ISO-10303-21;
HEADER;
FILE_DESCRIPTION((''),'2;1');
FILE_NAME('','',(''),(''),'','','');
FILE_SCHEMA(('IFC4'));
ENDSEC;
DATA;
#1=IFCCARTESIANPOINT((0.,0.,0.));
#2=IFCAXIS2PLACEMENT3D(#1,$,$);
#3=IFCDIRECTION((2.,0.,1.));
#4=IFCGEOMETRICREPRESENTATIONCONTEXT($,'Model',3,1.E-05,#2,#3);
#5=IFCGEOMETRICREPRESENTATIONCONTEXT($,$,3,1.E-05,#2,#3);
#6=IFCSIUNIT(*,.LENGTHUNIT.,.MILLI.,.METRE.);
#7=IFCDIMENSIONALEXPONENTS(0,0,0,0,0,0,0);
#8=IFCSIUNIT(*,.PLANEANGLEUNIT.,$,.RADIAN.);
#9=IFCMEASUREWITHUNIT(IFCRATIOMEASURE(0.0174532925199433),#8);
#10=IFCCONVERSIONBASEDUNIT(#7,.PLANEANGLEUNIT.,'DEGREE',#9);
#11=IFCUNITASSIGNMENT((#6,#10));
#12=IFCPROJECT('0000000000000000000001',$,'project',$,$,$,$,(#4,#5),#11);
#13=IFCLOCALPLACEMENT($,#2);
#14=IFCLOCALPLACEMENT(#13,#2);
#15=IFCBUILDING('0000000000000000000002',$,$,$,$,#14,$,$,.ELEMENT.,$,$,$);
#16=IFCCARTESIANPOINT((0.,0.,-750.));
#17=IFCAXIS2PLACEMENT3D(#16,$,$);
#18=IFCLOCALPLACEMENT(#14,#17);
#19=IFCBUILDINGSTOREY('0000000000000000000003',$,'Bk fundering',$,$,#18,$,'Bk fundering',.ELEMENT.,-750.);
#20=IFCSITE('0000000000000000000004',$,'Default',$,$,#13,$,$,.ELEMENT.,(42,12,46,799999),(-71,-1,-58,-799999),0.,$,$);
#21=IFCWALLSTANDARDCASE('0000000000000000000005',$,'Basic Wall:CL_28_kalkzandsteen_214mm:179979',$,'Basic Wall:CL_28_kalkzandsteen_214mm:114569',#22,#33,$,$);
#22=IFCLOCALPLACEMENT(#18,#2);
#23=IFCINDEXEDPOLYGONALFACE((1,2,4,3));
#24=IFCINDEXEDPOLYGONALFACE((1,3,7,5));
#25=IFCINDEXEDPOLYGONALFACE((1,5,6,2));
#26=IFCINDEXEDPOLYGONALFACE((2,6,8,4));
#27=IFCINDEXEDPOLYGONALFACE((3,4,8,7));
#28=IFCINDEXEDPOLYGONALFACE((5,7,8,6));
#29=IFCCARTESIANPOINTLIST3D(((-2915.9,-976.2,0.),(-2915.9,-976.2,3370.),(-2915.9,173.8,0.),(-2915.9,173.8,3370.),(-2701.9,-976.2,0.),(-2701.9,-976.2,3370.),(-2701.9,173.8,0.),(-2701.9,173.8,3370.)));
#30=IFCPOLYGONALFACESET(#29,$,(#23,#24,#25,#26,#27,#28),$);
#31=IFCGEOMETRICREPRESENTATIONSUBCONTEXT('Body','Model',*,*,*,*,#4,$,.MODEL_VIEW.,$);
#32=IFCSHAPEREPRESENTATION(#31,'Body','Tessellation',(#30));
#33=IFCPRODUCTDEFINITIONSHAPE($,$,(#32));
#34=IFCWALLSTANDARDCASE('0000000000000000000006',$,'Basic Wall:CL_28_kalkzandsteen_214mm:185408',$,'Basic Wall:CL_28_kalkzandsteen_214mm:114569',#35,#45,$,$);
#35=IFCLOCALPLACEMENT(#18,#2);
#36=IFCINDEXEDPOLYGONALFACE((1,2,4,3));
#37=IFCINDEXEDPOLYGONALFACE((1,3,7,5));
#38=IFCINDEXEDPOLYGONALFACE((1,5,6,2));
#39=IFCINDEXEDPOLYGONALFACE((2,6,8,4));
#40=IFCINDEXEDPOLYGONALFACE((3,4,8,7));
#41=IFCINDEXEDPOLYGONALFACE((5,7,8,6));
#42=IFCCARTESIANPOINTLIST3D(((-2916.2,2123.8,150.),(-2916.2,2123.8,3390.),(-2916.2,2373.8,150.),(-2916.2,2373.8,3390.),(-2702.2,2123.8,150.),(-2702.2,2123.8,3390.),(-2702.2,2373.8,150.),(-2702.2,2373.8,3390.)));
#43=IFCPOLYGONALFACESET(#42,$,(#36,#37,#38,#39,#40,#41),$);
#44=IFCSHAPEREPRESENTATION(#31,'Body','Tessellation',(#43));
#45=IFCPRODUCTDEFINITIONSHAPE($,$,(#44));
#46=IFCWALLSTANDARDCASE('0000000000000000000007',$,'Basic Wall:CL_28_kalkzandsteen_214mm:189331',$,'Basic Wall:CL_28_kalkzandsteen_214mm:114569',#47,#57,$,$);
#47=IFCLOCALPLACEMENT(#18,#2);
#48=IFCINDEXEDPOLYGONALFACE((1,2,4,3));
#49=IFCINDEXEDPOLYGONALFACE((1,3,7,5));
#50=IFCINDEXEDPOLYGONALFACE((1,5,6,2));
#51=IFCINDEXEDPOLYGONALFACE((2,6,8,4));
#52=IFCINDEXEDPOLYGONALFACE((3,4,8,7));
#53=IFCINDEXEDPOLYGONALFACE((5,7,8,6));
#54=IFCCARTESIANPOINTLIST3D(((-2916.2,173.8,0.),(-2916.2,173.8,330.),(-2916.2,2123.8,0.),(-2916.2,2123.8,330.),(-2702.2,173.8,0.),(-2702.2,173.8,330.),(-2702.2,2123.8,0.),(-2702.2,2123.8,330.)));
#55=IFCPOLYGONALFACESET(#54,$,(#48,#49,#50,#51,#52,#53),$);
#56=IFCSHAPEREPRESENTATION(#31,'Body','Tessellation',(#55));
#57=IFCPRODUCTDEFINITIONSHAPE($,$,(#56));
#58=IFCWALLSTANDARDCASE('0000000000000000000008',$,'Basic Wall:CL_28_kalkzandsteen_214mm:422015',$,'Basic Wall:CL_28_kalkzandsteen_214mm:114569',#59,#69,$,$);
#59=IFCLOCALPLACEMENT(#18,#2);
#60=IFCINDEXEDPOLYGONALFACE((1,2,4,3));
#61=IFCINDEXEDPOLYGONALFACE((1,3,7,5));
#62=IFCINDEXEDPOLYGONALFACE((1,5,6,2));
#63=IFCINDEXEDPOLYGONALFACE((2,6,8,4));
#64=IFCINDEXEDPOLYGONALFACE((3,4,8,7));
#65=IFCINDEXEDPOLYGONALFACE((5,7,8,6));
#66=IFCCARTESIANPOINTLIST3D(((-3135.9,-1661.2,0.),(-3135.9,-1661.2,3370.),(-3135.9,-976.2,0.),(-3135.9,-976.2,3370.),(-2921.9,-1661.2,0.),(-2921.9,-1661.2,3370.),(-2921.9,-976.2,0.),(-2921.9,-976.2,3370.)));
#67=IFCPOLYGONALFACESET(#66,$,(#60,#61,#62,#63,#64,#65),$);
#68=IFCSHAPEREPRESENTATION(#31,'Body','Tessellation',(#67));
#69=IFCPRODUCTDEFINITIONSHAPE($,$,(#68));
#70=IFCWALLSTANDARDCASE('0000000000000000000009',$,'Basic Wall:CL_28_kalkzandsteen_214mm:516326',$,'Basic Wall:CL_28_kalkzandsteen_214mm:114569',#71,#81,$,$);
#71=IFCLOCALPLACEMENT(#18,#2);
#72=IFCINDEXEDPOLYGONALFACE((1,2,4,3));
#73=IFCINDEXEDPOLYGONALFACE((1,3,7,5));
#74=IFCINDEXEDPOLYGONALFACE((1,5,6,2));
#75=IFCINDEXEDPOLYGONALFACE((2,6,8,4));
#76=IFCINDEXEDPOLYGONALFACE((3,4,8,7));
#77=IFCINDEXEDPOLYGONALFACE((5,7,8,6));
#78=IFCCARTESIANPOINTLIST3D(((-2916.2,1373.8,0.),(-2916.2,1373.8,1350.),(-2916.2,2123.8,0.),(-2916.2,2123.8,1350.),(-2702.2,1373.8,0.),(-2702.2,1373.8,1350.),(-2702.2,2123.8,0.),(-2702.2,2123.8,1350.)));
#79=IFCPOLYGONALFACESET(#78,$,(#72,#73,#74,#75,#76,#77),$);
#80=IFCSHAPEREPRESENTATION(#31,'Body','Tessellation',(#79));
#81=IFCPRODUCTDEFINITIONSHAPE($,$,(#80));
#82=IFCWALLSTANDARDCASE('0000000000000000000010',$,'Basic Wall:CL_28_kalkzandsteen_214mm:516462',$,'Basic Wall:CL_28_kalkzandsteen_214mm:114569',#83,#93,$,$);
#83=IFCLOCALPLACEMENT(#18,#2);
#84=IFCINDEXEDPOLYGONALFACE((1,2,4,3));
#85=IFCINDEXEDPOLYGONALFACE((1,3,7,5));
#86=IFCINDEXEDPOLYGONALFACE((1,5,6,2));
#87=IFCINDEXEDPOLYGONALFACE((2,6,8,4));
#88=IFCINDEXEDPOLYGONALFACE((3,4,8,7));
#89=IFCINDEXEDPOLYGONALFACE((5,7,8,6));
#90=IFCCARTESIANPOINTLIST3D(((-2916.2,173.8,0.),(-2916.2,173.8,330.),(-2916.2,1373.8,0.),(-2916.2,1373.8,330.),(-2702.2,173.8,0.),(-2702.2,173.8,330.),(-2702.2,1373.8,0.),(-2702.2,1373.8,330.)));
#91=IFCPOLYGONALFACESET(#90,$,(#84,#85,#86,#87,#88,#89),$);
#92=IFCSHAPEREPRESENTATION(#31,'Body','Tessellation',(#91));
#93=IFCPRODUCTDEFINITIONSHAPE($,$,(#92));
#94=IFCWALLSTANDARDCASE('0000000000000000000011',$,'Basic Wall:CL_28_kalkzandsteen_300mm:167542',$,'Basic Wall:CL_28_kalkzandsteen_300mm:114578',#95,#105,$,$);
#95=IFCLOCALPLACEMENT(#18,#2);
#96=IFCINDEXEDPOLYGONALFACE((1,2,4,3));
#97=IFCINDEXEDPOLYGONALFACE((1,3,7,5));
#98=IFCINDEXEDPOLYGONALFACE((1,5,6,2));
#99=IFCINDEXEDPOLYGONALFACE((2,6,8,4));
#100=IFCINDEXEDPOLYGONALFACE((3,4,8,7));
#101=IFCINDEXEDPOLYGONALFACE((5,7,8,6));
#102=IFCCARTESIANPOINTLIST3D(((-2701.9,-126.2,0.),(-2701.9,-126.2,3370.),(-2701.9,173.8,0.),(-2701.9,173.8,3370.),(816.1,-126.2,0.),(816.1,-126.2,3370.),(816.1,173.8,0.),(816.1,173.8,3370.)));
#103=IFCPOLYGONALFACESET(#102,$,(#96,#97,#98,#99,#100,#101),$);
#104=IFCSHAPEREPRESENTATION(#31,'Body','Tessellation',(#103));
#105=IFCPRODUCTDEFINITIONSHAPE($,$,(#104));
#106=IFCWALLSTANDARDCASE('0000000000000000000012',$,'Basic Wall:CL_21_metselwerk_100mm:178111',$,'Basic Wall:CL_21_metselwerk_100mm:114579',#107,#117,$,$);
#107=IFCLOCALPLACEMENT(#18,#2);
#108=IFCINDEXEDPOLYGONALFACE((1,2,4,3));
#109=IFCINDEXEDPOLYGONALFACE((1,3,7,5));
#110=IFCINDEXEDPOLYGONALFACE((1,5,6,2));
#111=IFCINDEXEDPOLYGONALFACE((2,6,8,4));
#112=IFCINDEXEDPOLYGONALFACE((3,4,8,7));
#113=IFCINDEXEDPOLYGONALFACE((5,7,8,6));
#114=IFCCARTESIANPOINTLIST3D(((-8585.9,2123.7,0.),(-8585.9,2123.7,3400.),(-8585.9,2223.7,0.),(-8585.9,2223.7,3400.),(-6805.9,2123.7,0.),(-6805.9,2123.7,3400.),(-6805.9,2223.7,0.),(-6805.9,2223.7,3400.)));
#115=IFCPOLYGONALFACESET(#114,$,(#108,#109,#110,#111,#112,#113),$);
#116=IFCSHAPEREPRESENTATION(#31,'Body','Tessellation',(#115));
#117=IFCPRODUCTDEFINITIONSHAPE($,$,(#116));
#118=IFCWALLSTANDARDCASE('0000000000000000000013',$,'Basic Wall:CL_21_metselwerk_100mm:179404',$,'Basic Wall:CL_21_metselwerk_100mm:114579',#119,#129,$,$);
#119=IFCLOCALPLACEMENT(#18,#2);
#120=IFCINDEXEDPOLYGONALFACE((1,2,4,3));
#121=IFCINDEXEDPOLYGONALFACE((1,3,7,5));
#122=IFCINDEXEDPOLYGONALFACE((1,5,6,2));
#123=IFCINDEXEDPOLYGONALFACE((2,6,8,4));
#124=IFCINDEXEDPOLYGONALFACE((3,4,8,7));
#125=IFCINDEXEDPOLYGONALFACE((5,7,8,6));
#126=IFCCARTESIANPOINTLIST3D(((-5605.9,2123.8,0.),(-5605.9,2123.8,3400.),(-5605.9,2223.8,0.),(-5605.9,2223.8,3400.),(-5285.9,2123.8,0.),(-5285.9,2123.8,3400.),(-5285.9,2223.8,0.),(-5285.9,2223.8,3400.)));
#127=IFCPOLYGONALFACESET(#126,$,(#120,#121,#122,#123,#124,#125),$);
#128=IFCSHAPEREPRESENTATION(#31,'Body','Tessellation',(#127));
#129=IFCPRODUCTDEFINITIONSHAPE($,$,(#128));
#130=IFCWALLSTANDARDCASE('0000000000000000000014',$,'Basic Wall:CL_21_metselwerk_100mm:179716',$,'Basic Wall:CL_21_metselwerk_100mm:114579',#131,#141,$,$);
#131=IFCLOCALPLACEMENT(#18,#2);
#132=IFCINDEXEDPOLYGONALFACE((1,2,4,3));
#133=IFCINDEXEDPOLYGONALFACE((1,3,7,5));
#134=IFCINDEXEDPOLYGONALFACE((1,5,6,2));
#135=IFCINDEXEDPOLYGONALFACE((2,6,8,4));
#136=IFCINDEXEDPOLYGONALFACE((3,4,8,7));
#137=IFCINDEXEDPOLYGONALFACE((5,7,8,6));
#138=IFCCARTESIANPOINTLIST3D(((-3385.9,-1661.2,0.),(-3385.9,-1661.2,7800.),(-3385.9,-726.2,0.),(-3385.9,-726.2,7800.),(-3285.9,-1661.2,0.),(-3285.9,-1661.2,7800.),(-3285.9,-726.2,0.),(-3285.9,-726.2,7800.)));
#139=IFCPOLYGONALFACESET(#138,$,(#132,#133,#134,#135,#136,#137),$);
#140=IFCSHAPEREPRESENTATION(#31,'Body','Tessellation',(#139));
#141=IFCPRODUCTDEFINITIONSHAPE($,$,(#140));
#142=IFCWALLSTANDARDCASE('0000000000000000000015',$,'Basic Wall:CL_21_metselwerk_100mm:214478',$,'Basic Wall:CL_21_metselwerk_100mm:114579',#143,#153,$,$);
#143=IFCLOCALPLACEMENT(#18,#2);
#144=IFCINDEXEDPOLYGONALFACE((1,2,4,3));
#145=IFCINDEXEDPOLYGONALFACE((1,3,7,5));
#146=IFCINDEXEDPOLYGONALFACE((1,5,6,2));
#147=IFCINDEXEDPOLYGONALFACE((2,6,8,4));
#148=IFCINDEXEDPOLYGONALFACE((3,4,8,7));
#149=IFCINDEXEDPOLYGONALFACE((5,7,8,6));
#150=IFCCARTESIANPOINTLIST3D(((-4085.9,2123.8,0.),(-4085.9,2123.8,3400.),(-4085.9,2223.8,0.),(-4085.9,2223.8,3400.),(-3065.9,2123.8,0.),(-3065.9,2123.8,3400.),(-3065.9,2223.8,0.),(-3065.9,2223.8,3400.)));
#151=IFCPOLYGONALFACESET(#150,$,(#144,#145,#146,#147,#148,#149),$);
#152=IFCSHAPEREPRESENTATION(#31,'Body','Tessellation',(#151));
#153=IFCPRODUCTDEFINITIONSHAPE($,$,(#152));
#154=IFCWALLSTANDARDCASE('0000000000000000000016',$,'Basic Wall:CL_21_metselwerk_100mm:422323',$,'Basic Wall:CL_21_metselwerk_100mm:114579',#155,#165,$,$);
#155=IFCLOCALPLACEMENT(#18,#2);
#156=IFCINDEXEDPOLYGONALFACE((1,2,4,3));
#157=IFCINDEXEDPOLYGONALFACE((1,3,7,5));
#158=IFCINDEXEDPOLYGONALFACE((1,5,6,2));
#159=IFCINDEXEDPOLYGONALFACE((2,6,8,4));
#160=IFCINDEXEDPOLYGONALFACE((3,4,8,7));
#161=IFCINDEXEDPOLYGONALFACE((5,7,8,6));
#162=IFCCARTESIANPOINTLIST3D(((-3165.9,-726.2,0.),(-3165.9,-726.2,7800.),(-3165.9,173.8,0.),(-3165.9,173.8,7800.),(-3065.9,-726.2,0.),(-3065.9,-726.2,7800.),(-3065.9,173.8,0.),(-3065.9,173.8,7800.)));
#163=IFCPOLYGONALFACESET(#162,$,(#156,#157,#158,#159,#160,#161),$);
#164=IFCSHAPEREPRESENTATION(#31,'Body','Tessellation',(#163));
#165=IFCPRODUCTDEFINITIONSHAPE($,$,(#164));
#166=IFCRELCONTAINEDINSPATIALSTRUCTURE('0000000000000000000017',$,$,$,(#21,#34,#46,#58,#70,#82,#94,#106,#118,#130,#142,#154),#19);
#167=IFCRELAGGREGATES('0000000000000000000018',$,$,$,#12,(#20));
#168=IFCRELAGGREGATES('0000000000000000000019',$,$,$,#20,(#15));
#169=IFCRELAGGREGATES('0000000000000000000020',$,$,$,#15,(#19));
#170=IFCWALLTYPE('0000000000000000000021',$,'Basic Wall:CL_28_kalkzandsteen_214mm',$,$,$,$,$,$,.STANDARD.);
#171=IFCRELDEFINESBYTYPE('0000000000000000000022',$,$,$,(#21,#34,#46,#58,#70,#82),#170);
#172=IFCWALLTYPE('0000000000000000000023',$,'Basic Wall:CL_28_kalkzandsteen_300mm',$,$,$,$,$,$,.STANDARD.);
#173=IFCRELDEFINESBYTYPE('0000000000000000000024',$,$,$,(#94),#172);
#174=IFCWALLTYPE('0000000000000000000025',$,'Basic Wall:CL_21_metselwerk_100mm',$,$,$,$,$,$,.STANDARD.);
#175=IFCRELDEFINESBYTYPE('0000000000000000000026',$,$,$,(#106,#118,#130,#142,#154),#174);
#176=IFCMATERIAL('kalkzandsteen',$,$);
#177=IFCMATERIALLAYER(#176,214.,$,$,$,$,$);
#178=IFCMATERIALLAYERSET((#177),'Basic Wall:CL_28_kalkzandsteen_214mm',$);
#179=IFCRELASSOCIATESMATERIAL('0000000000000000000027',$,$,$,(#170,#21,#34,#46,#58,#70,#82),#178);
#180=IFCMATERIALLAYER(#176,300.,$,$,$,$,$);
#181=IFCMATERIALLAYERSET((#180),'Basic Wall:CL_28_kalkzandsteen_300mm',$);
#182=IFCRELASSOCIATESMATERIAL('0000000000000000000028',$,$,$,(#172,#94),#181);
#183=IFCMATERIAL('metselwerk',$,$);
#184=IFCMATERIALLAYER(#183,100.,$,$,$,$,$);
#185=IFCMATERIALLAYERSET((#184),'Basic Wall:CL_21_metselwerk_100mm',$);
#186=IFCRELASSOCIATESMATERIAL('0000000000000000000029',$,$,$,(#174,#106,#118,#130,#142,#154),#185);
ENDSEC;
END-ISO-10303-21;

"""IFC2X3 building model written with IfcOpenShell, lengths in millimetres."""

from ifc_helpers import new_model, entity, si_unit, converted_unit, direction, frame, frame_2d, origin, place, context, subcontext, project, spatial, polyline, rectangle, extrude, clip, bounded_halfspace, material, layer, layer_set, layer_usage, type_object, element, save


model = new_model("IFC2X3")

# Units and contexts
model_context = context("Model", 3, precision=1e-05, world=origin(), true_north=direction((2.0, 0.0, 1.0)))
context_of_model = context(None, 3, precision=1e-05, world=origin(), true_north=direction((2.0, 0.0, 1.0)))
body_context = subcontext(model_context, "Body", "Model", "MODEL_VIEW")
ifc_project = project(units=[si_unit("LENGTHUNIT", "METRE", prefix="MILLI"), converted_unit("PLANEANGLEUNIT", "DEGREE", entity("IfcRatioMeasure", 0.0174532925199433), si_unit("PLANEANGLEUNIT", "RADIAN"), dimensions=[0, 0, 0, 0, 0, 0, 0])], contexts=[model_context, context_of_model])

# Site, building, storey
site_placement = place(None, origin())
site = spatial("IfcSite", under=ifc_project, at=site_placement, Name="Default", CompositionType="ELEMENT", RefLatitude=(42, 12, 46, 799999), RefLongitude=(-71, -1, -58, -799999), RefElevation=0.0)
building_placement = place(site_placement, origin())
building = spatial("IfcBuilding", under=site, at=building_placement, CompositionType="ELEMENT")
storey_placement = place(building_placement, frame((0.0, 0.0, -750.0)))
storey = spatial("IfcBuildingStorey", under=building, at=storey_placement, Name="Bk fundering", LongName="Bk fundering", CompositionType="ELEMENT", Elevation=-750.0)

# Walls
ifc_material_1 = material(Name="kalkzandsteen")
ifc_layer_1 = layer(ifc_material_1, 214.0)
ifc_layer_set_1 = layer_set([ifc_layer_1], Name="Basic Wall:CL_28_kalkzandsteen_214mm")
ifc_layer_usage_1 = layer_usage(ifc_layer_set_1, "AXIS2", "NEGATIVE", 107.0)
wall_type_1 = type_object("IfcWallType", Name="Basic Wall:CL_28_kalkzandsteen_214mm", PredefinedType="STANDARD", material=ifc_layer_set_1)
wall_1_placement = place(storey_placement, frame((-2808.9, 173.8, 0.0), z_axis=(0.0, 0.0, 1.0), x_axis=(0.0, -1.0, 0.0)))
element("IfcWallStandardCase", 1, at=wall_1_placement, inside=storey, type_object=wall_type_1, material=ifc_layer_usage_1, Name="Basic Wall:CL_28_kalkzandsteen_214mm:179979", ObjectType="Basic Wall:CL_28_kalkzandsteen_214mm:114569", context=body_context, shape_type="Clipping", body=[
    clip(extrude(rectangle(XDim=1150.0, YDim=214.0, at=frame_2d((575.0, 0.0), x_axis=(-1.0, 0.0))), origin(), (0.0, 0.0, 1.0), 3370.0), bounded_halfspace(frame((0.0, -107.0, 3370.0), z_axis=(0.0, 0.0, -1.0), x_axis=(0.0, 1.0, 0.0)), True, frame((0.0, -107.0, 3370.0)), polyline([(0.0, 0.0), (1150.0, 0.0), (1150.0, 214.0), (300.0, 214.0), (0.0, 214.0), (0.0, 0.0)]))),
])
ifc_layer_usage_2 = layer_usage(ifc_layer_set_1, "AXIS2", "NEGATIVE", 107.0)
wall_2_placement = place(storey_placement, frame((-2809.2, 2373.8, 150.0), z_axis=(0.0, 0.0, 1.0), x_axis=(0.0, -1.0, 0.0)))
element("IfcWallStandardCase", 2, at=wall_2_placement, inside=storey, type_object=wall_type_1, material=ifc_layer_usage_2, Name="Basic Wall:CL_28_kalkzandsteen_214mm:185408", ObjectType="Basic Wall:CL_28_kalkzandsteen_214mm:114569", context=body_context, shape_type="SweptSolid", body=[
    extrude(rectangle(XDim=250.0, YDim=214.0, at=frame_2d((125.0, 0.0), x_axis=(-1.0, 0.0))), origin(), (0.0, 0.0, 1.0), 3240.0),
])
ifc_layer_usage_3 = layer_usage(ifc_layer_set_1, "AXIS2", "NEGATIVE", 107.0)
wall_3_placement = place(storey_placement, frame((-2809.2, 2123.8, 0.0), z_axis=(0.0, 0.0, 1.0), x_axis=(0.0, -1.0, 0.0)))
element("IfcWallStandardCase", 3, at=wall_3_placement, inside=storey, type_object=wall_type_1, material=ifc_layer_usage_3, Name="Basic Wall:CL_28_kalkzandsteen_214mm:189331", ObjectType="Basic Wall:CL_28_kalkzandsteen_214mm:114569", context=body_context, shape_type="SweptSolid", body=[
    extrude(rectangle(XDim=1950.0, YDim=214.0, at=frame_2d((975.0, 0.0), x_axis=(-1.0, 0.0))), origin(), (0.0, 0.0, 1.0), 330.0),
])
ifc_layer_usage_4 = layer_usage(ifc_layer_set_1, "AXIS2", "NEGATIVE", 107.0)
wall_4_placement = place(storey_placement, frame((-3028.9, -976.2, 0.0), z_axis=(0.0, 0.0, 1.0), x_axis=(0.0, -1.0, 0.0)))
element("IfcWallStandardCase", 4, at=wall_4_placement, inside=storey, type_object=wall_type_1, material=ifc_layer_usage_4, Name="Basic Wall:CL_28_kalkzandsteen_214mm:422015", ObjectType="Basic Wall:CL_28_kalkzandsteen_214mm:114569", context=body_context, shape_type="Clipping", body=[
    clip(extrude(rectangle(XDim=685.0, YDim=214.0, at=frame_2d((342.5, 0.0), x_axis=(-1.0, 0.0))), origin(), (0.0, 0.0, 1.0), 3370.0), bounded_halfspace(frame((0.0, -107.0, 3370.0), z_axis=(0.0, 0.0, -1.0), x_axis=(0.0, 1.0, 0.0)), True, frame((0.0, -107.0, 3370.0)), polyline([(0.0, 0.0), (685.0, 0.0), (685.0, 214.0), (0.0, 214.0), (0.0, 0.0)]))),
])
ifc_layer_usage_5 = layer_usage(ifc_layer_set_1, "AXIS2", "NEGATIVE", 107.0)
wall_5_placement = place(storey_placement, frame((-2809.2, 1373.8, 0.0), z_axis=(0.0, 0.0, 1.0), x_axis=(0.0, 1.0, 0.0)))
element("IfcWallStandardCase", 5, at=wall_5_placement, inside=storey, type_object=wall_type_1, material=ifc_layer_usage_5, Name="Basic Wall:CL_28_kalkzandsteen_214mm:516326", ObjectType="Basic Wall:CL_28_kalkzandsteen_214mm:114569", context=body_context, shape_type="SweptSolid", body=[
    extrude(rectangle(XDim=750.0, YDim=214.0, at=frame_2d((375.0, 0.0), x_axis=(-1.0, 0.0))), origin(), (0.0, 0.0, 1.0), 1350.0),
])
ifc_layer_usage_6 = layer_usage(ifc_layer_set_1, "AXIS2", "NEGATIVE", 107.0)
wall_6_placement = place(storey_placement, frame((-2809.2, 173.8, 0.0), z_axis=(0.0, 0.0, 1.0), x_axis=(0.0, 1.0, 0.0)))
element("IfcWallStandardCase", 6, at=wall_6_placement, inside=storey, type_object=wall_type_1, material=ifc_layer_usage_6, Name="Basic Wall:CL_28_kalkzandsteen_214mm:516462", ObjectType="Basic Wall:CL_28_kalkzandsteen_214mm:114569", context=body_context, shape_type="SweptSolid", body=[
    extrude(rectangle(XDim=1200.0, YDim=214.0, at=frame_2d((600.0, 0.0), x_axis=(-1.0, 0.0))), origin(), (0.0, 0.0, 1.0), 330.0),
])
ifc_layer_2 = layer(ifc_material_1, 300.0)
ifc_layer_set_2 = layer_set([ifc_layer_2], Name="Basic Wall:CL_28_kalkzandsteen_300mm")
ifc_layer_usage_7 = layer_usage(ifc_layer_set_2, "AXIS2", "NEGATIVE", 150.0)
wall_type_2 = type_object("IfcWallType", Name="Basic Wall:CL_28_kalkzandsteen_300mm", PredefinedType="STANDARD", material=ifc_layer_set_2)
wall_7_placement = place(storey_placement, frame((-2701.9, 23.8, 0.0)))
element("IfcWallStandardCase", 7, at=wall_7_placement, inside=storey, type_object=wall_type_2, material=ifc_layer_usage_7, Name="Basic Wall:CL_28_kalkzandsteen_300mm:167542", ObjectType="Basic Wall:CL_28_kalkzandsteen_300mm:114578", context=body_context, shape_type="Clipping", body=[
    clip(extrude(rectangle(XDim=3518.0, YDim=300.0, at=frame_2d((1759.0, 0.0), x_axis=(-1.0, 0.0))), origin(), (0.0, 0.0, 1.0), 3370.0), bounded_halfspace(frame((0.0, -150.0, 3370.0), z_axis=(0.0, 0.0, -1.0), x_axis=(1.0, 0.0, 0.0)), True, frame((0.0, -150.0, 3370.0)), polyline([(0.0, 0.0), (3518.0, 0.0), (3518.0, 300.0), (0.0, 300.0), (0.0, 0.0)]))),
])
ifc_material_2 = material(Name="metselwerk")
ifc_layer_3 = layer(ifc_material_2, 100.0)
ifc_layer_set_3 = layer_set([ifc_layer_3], Name="Basic Wall:CL_21_metselwerk_100mm")
ifc_layer_usage_8 = layer_usage(ifc_layer_set_3, "AXIS2", "NEGATIVE", 50.0)
wall_type_3 = type_object("IfcWallType", Name="Basic Wall:CL_21_metselwerk_100mm", PredefinedType="STANDARD", material=ifc_layer_set_3)
wall_8_placement = place(storey_placement, frame((-8585.9, 2173.7, 0.0)))
element("IfcWallStandardCase", 8, at=wall_8_placement, inside=storey, type_object=wall_type_3, material=ifc_layer_usage_8, Name="Basic Wall:CL_21_metselwerk_100mm:178111", ObjectType="Basic Wall:CL_21_metselwerk_100mm:114579", context=body_context, shape_type="SweptSolid", body=[
    extrude(rectangle(XDim=1780.0, YDim=100.0, at=frame_2d((890.0, 0.0), x_axis=(-1.0, 0.0))), origin(), (0.0, 0.0, 1.0), 3400.0),
])
ifc_layer_usage_9 = layer_usage(ifc_layer_set_3, "AXIS2", "NEGATIVE", 50.0)
wall_9_placement = place(storey_placement, frame((-5605.9, 2173.8, 0.0)))
element("IfcWallStandardCase", 9, at=wall_9_placement, inside=storey, type_object=wall_type_3, material=ifc_layer_usage_9, Name="Basic Wall:CL_21_metselwerk_100mm:179404", ObjectType="Basic Wall:CL_21_metselwerk_100mm:114579", context=body_context, shape_type="SweptSolid", body=[
    extrude(rectangle(XDim=320.0, YDim=100.0, at=frame_2d((160.0, 0.0), x_axis=(-1.0, 0.0))), origin(), (0.0, 0.0, 1.0), 3400.0),
])
ifc_layer_usage_10 = layer_usage(ifc_layer_set_3, "AXIS2", "NEGATIVE", 50.0)
wall_10_placement = place(storey_placement, frame((-3335.9, -726.2, 0.0), z_axis=(0.0, 0.0, 1.0), x_axis=(0.0, -1.0, 0.0)))
element("IfcWallStandardCase", 10, at=wall_10_placement, inside=storey, type_object=wall_type_3, material=ifc_layer_usage_10, Name="Basic Wall:CL_21_metselwerk_100mm:179716", ObjectType="Basic Wall:CL_21_metselwerk_100mm:114579", context=body_context, shape_type="SweptSolid", body=[
    extrude(rectangle(XDim=935.0, YDim=100.0, at=frame_2d((467.5, 0.0), x_axis=(-1.0, 0.0))), origin(), (0.0, 0.0, 1.0), 7800.0),
])
ifc_layer_usage_11 = layer_usage(ifc_layer_set_3, "AXIS2", "NEGATIVE", 50.0)
wall_11_placement = place(storey_placement, frame((-4085.9, 2173.8, 0.0)))
element("IfcWallStandardCase", 11, at=wall_11_placement, inside=storey, type_object=wall_type_3, material=ifc_layer_usage_11, Name="Basic Wall:CL_21_metselwerk_100mm:214478", ObjectType="Basic Wall:CL_21_metselwerk_100mm:114579", context=body_context, shape_type="SweptSolid", body=[
    extrude(rectangle(XDim=1020.0, YDim=100.0, at=frame_2d((510.0, 0.0), x_axis=(-1.0, 0.0))), origin(), (0.0, 0.0, 1.0), 3400.0),
])
ifc_layer_usage_12 = layer_usage(ifc_layer_set_3, "AXIS2", "NEGATIVE", 50.0)
wall_12_placement = place(storey_placement, frame((-3115.9, 173.8, 0.0), z_axis=(0.0, 0.0, 1.0), x_axis=(0.0, -1.0, 0.0)))
element("IfcWallStandardCase", 12, at=wall_12_placement, inside=storey, type_object=wall_type_3, material=ifc_layer_usage_12, Name="Basic Wall:CL_21_metselwerk_100mm:422323", ObjectType="Basic Wall:CL_21_metselwerk_100mm:114579", context=body_context, shape_type="SweptSolid", body=[
    extrude(rectangle(XDim=900.0, YDim=100.0, at=frame_2d((450.0, 0.0), x_axis=(-1.0, 0.0))), origin(), (0.0, 0.0, 1.0), 7800.0),
])

save(model, "model.ifc")
